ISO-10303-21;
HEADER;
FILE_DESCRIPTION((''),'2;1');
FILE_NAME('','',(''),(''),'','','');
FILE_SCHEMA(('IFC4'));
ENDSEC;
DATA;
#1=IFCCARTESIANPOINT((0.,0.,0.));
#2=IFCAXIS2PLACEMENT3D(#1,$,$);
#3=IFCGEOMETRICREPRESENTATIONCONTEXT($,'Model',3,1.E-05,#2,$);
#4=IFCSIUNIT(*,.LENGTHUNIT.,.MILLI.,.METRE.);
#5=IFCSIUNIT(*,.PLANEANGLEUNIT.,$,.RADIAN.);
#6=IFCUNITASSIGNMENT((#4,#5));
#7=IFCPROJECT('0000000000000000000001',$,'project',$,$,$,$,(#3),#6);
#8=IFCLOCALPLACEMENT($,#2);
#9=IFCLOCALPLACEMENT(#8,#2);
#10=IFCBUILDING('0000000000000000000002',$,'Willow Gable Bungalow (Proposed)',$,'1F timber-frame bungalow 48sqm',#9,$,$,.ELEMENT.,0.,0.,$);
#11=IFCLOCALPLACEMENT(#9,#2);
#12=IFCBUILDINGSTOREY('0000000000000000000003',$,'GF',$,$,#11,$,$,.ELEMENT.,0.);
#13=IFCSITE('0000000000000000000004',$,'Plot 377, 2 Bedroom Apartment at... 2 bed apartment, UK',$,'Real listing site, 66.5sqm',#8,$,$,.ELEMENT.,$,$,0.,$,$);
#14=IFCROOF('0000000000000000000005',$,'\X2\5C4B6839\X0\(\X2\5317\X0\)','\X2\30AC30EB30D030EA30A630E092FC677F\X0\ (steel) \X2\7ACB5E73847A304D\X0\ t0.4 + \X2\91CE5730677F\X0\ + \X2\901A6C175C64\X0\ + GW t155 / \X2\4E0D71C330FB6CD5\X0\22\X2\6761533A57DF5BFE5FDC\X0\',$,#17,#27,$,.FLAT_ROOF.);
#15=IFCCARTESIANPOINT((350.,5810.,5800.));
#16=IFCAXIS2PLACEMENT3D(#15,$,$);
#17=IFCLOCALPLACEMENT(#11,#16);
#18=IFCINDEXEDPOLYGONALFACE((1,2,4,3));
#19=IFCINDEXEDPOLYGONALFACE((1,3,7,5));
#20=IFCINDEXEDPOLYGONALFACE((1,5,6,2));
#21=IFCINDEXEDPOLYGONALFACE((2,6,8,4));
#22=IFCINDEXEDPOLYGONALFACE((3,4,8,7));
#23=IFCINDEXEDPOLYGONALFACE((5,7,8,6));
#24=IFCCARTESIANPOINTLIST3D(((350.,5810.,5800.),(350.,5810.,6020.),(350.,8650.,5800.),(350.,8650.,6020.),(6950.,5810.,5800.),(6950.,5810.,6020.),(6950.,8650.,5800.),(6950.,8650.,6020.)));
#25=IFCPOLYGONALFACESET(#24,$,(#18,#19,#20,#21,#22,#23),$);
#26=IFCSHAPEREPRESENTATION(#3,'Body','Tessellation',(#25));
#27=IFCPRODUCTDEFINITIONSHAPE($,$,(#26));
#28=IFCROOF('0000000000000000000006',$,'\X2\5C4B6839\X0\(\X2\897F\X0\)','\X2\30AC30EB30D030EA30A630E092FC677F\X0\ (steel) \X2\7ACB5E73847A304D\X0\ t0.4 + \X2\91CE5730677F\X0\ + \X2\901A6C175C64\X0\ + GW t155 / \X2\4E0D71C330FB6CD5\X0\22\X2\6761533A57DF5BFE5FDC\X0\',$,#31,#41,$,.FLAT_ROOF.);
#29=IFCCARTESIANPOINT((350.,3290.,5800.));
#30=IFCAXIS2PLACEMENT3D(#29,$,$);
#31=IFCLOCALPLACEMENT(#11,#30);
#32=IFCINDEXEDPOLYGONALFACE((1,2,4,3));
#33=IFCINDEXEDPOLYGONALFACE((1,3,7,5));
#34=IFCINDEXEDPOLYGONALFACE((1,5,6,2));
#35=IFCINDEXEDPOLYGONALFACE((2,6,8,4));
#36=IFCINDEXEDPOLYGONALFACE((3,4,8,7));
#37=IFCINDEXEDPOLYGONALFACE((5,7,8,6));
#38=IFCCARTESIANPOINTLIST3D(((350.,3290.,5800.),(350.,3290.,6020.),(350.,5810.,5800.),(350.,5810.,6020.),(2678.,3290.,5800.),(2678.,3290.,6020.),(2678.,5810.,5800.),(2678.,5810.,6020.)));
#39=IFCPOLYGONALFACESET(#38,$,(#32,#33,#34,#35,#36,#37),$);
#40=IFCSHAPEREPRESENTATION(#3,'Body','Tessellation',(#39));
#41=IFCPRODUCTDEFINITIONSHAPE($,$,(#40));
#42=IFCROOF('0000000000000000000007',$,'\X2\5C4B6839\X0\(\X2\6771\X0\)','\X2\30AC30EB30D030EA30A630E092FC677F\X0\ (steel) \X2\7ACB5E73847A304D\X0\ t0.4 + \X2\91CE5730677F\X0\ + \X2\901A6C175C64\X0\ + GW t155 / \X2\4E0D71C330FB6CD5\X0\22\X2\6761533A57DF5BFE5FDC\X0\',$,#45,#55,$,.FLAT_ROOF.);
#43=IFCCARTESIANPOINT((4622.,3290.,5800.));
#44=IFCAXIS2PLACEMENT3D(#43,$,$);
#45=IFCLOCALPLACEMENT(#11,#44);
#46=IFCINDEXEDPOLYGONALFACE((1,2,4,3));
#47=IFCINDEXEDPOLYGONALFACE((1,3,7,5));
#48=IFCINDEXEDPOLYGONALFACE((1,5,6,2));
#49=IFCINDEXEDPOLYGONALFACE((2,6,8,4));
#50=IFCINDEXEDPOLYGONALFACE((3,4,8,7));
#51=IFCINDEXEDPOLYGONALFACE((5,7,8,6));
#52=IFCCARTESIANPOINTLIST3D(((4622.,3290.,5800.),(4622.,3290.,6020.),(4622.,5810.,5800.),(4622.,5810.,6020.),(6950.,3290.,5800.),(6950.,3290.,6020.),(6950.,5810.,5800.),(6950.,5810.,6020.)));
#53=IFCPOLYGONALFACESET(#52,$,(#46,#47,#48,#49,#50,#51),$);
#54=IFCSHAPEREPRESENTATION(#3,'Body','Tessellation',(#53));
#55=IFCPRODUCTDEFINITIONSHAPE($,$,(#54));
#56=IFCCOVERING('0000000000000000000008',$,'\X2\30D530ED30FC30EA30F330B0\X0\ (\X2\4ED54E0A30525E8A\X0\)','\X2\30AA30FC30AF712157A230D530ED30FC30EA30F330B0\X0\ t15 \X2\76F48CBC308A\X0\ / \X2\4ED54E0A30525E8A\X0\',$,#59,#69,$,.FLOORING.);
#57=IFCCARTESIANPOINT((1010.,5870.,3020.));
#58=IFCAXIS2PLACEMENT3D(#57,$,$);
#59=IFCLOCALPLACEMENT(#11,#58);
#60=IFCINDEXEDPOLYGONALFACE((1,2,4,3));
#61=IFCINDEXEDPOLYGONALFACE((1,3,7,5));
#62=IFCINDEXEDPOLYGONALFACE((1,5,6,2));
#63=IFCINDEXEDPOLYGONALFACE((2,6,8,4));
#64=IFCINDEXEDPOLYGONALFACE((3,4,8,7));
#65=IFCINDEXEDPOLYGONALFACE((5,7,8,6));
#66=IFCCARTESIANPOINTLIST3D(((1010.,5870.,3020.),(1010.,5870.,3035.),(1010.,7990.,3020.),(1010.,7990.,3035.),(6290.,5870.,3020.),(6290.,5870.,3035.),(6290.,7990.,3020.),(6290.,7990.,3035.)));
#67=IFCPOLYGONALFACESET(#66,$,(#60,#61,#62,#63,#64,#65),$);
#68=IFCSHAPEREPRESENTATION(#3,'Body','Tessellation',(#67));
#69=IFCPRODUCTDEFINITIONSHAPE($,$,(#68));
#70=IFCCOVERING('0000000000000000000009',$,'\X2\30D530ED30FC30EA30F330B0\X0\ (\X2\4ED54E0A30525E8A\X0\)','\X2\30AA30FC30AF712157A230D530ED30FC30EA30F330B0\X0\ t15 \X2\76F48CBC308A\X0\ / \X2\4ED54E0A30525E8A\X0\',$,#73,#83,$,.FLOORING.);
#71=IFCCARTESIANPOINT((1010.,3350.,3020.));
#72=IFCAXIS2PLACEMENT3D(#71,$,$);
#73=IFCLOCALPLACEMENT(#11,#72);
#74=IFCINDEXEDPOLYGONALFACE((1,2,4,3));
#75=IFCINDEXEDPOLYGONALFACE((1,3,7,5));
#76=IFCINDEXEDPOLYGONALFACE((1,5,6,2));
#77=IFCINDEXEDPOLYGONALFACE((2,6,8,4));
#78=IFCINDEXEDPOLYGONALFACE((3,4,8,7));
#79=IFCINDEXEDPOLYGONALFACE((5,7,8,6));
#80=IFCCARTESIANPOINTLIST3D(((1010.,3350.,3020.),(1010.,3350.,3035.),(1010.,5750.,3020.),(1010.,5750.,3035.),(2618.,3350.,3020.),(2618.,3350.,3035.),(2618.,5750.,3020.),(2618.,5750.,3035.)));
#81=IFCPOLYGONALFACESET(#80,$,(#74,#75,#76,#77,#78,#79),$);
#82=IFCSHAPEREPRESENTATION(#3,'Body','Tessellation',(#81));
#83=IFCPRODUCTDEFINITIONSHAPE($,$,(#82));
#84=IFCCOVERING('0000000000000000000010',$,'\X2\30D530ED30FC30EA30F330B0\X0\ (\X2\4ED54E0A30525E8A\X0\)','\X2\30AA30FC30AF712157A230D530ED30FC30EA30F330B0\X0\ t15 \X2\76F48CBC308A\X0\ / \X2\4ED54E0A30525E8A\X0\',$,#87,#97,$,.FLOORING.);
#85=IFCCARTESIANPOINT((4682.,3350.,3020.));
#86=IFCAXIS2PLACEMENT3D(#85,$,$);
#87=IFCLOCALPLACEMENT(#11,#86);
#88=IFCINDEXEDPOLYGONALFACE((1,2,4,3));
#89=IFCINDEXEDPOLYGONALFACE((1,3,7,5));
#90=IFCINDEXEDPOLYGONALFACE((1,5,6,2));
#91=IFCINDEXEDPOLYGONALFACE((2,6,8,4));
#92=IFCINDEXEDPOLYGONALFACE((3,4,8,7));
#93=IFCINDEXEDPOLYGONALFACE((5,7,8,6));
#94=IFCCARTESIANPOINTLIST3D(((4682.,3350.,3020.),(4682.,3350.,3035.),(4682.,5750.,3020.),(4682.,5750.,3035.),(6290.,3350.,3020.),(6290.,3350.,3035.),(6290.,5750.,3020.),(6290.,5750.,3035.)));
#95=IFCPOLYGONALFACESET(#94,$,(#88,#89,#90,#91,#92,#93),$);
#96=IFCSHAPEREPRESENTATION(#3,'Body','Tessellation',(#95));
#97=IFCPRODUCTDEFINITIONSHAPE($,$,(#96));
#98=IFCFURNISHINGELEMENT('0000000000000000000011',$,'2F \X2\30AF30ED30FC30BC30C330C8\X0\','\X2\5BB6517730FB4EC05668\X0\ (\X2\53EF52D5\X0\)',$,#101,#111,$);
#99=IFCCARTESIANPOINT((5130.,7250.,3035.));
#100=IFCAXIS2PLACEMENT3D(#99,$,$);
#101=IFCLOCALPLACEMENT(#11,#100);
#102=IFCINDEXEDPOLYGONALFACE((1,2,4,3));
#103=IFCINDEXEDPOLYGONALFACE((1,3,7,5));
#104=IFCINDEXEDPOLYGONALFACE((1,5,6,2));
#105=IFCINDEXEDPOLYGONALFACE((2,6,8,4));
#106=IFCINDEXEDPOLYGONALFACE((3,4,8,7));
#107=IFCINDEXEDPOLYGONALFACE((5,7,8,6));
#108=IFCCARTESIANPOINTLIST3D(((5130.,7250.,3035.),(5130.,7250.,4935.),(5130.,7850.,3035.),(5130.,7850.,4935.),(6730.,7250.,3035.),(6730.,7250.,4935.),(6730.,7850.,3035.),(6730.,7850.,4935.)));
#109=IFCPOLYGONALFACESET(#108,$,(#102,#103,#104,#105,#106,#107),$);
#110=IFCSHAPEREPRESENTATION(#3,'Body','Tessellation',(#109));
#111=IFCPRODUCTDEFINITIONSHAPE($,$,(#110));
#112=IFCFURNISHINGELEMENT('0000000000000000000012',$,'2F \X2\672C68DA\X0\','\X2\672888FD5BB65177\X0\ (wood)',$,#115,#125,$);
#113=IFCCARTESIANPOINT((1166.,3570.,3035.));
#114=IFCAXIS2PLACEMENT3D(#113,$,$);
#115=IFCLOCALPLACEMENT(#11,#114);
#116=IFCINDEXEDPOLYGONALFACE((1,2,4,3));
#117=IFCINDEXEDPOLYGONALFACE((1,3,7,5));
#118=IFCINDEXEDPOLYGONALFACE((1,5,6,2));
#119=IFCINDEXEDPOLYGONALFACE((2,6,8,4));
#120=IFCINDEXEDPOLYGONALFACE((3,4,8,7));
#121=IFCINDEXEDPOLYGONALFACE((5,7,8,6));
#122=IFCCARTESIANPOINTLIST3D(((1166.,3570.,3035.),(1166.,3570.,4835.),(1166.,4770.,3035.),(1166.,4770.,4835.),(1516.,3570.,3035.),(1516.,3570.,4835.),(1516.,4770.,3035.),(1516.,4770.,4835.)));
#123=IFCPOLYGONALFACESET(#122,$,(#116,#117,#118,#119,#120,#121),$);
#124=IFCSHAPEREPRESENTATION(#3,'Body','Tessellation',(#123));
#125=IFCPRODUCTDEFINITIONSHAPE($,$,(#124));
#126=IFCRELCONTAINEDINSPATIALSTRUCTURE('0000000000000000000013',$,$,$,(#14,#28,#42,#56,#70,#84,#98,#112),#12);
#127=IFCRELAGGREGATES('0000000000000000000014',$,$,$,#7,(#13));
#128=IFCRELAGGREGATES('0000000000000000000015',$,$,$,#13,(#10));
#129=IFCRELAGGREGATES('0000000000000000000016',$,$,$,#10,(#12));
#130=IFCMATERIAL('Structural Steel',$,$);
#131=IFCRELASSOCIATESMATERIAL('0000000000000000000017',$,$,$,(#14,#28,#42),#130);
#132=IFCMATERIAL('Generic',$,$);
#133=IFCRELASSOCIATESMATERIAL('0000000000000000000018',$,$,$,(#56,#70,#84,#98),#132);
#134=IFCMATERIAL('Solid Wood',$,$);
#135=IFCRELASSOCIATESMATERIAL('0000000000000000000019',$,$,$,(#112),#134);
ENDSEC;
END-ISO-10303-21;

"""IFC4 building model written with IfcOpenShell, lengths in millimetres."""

from ifc_helpers import new_model, si_unit, frame, frame_2d, origin, place, context, project, spatial, rectangle, extrude, material, element, save


model = new_model("IFC4")

# Units and contexts
model_context = context("Model", 3, precision=1e-05, world=origin())
ifc_project = project(units=[si_unit("LENGTHUNIT", "METRE", prefix="MILLI"), si_unit("PLANEANGLEUNIT", "RADIAN")], contexts=[model_context])

# Site, building, storey
site_placement = place(None, origin())
site = spatial("IfcSite", under=ifc_project, at=site_placement, Name="Plot 377, 2 Bedroom Apartment at... 2 bed apartment, UK", ObjectType="Real listing site, 66.5sqm", CompositionType="ELEMENT", RefElevation=0.0)
building_placement = place(site_placement, origin())
building = spatial("IfcBuilding", under=site, at=building_placement, Name="Willow Gable Bungalow (Proposed)", ObjectType="1F timber-frame bungalow 48sqm", CompositionType="ELEMENT", ElevationOfRefHeight=0.0, ElevationOfTerrain=0.0)
storey_placement = place(building_placement, origin())
storey = spatial("IfcBuildingStorey", under=building, at=storey_placement, Name="GF", CompositionType="ELEMENT", Elevation=0.0)

# Shared definitions
ifc_material_1 = material(Name="Solid Wood")

# Shared definitions
ifc_material_2 = material(Name="Generic")

# Roofs
ifc_material_3 = material(Name="Structural Steel")
for number, where, name in (
    (1, (350.0, 5810.0, 5800.0), "屋根(北)"),
):
    element("IfcRoof", number, at=place(storey_placement, frame(where)), inside=storey, material=ifc_material_3, Name=name, Description="ガルバリウム鋼板 (steel) 立平葺き t0.4 + 野地板 + 通気層 + GW t155 / 不燃・法22条区域対応", PredefinedType="FLAT_ROOF", context=model_context, shape_type="SweptSolid", body=[
        extrude(rectangle(XDim=6600.0, YDim=2840.0, at=frame_2d((3300.0, 1420.0))), frame((350.0, 5810.0, 5800.0)), (0.0, 0.0, 1.0), 220.0),
    ])
roof_1_placement = place(storey_placement, frame((350.0, 3290.0, 5800.0)))
element("IfcRoof", 2, at=roof_1_placement, inside=storey, material=ifc_material_3, Name="屋根(西)", Description="ガルバリウム鋼板 (steel) 立平葺き t0.4 + 野地板 + 通気層 + GW t155 / 不燃・法22条区域対応", PredefinedType="FLAT_ROOF", context=model_context, shape_type="SweptSolid", body=[
    extrude(rectangle(XDim=2328.0, YDim=2520.0, at=frame_2d((1164.0, 1260.0))), frame((350.0, 3290.0, 5800.0)), (0.0, 0.0, 1.0), 220.0),
])
roof_2_placement = place(storey_placement, frame((4622.0, 3290.0, 5800.0)))
element("IfcRoof", 3, at=roof_2_placement, inside=storey, material=ifc_material_3, Name="屋根(東)", Description="ガルバリウム鋼板 (steel) 立平葺き t0.4 + 野地板 + 通気層 + GW t155 / 不燃・法22条区域対応", PredefinedType="FLAT_ROOF", context=model_context, shape_type="SweptSolid", body=[
    extrude(rectangle(XDim=2328.0, YDim=2520.0, at=frame_2d((1164.0, 1260.0))), frame((4622.0, 3290.0, 5800.0)), (0.0, 0.0, 1.0), 220.0),
])

# Coverings
covering_1_placement = place(storey_placement, frame((1010.0, 5870.0, 3020.0)))
element("IfcCovering", 4, at=covering_1_placement, inside=storey, material=ifc_material_2, Name="フローリング (仕上げ床)", Description="オーク無垢フローリング t15 直貼り / 仕上げ床", PredefinedType="FLOORING", context=model_context, shape_type="SweptSolid", body=[
    extrude(rectangle(XDim=5280.0, YDim=2120.0, at=frame_2d((2640.0, 1060.0))), frame((1010.0, 5870.0, 3020.0)), (0.0, 0.0, 1.0), 15.0),
])
covering_2_placement = place(storey_placement, frame((1010.0, 3350.0, 3020.0)))
element("IfcCovering", 5, at=covering_2_placement, inside=storey, material=ifc_material_2, Name="フローリング (仕上げ床)", Description="オーク無垢フローリング t15 直貼り / 仕上げ床", PredefinedType="FLOORING", context=model_context, shape_type="SweptSolid", body=[
    extrude(rectangle(XDim=1608.0, YDim=2400.0, at=frame_2d((804.0, 1200.0))), frame((1010.0, 3350.0, 3020.0)), (0.0, 0.0, 1.0), 15.0),
])
covering_3_placement = place(storey_placement, frame((4682.0, 3350.0, 3020.0)))
element("IfcCovering", 6, at=covering_3_placement, inside=storey, material=ifc_material_2, Name="フローリング (仕上げ床)", Description="オーク無垢フローリング t15 直貼り / 仕上げ床", PredefinedType="FLOORING", context=model_context, shape_type="SweptSolid", body=[
    extrude(rectangle(XDim=1608.0, YDim=2400.0, at=frame_2d((804.0, 1200.0))), frame((4682.0, 3350.0, 3020.0)), (0.0, 0.0, 1.0), 15.0),
])

# Furnishing elements
furnishing_1_placement = place(storey_placement, frame((5130.0, 7250.0, 3035.0)))
element("IfcFurnishingElement", 7, at=furnishing_1_placement, inside=storey, material=ifc_material_2, Name="2F クローゼット", Description="家具・什器 (可動)", context=model_context, shape_type="SweptSolid", body=[
    extrude(rectangle(XDim=1600.0, YDim=600.0, at=frame_2d((800.0, 300.0))), frame((5130.0, 7250.0, 3035.0)), (0.0, 0.0, 1.0), 1900.0),
])
furnishing_2_placement = place(storey_placement, frame((1166.0, 3570.0, 3035.0)))
element("IfcFurnishingElement", 8, at=furnishing_2_placement, inside=storey, material=ifc_material_1, Name="2F 本棚", Description="木製家具 (wood)", context=model_context, shape_type="SweptSolid", body=[
    extrude(rectangle(XDim=350.0, YDim=1200.0, at=frame_2d((175.0, 600.0))), frame((1166.0, 3570.0, 3035.0)), (0.0, 0.0, 1.0), 1800.0),
])

save(model, "model.ifc")
